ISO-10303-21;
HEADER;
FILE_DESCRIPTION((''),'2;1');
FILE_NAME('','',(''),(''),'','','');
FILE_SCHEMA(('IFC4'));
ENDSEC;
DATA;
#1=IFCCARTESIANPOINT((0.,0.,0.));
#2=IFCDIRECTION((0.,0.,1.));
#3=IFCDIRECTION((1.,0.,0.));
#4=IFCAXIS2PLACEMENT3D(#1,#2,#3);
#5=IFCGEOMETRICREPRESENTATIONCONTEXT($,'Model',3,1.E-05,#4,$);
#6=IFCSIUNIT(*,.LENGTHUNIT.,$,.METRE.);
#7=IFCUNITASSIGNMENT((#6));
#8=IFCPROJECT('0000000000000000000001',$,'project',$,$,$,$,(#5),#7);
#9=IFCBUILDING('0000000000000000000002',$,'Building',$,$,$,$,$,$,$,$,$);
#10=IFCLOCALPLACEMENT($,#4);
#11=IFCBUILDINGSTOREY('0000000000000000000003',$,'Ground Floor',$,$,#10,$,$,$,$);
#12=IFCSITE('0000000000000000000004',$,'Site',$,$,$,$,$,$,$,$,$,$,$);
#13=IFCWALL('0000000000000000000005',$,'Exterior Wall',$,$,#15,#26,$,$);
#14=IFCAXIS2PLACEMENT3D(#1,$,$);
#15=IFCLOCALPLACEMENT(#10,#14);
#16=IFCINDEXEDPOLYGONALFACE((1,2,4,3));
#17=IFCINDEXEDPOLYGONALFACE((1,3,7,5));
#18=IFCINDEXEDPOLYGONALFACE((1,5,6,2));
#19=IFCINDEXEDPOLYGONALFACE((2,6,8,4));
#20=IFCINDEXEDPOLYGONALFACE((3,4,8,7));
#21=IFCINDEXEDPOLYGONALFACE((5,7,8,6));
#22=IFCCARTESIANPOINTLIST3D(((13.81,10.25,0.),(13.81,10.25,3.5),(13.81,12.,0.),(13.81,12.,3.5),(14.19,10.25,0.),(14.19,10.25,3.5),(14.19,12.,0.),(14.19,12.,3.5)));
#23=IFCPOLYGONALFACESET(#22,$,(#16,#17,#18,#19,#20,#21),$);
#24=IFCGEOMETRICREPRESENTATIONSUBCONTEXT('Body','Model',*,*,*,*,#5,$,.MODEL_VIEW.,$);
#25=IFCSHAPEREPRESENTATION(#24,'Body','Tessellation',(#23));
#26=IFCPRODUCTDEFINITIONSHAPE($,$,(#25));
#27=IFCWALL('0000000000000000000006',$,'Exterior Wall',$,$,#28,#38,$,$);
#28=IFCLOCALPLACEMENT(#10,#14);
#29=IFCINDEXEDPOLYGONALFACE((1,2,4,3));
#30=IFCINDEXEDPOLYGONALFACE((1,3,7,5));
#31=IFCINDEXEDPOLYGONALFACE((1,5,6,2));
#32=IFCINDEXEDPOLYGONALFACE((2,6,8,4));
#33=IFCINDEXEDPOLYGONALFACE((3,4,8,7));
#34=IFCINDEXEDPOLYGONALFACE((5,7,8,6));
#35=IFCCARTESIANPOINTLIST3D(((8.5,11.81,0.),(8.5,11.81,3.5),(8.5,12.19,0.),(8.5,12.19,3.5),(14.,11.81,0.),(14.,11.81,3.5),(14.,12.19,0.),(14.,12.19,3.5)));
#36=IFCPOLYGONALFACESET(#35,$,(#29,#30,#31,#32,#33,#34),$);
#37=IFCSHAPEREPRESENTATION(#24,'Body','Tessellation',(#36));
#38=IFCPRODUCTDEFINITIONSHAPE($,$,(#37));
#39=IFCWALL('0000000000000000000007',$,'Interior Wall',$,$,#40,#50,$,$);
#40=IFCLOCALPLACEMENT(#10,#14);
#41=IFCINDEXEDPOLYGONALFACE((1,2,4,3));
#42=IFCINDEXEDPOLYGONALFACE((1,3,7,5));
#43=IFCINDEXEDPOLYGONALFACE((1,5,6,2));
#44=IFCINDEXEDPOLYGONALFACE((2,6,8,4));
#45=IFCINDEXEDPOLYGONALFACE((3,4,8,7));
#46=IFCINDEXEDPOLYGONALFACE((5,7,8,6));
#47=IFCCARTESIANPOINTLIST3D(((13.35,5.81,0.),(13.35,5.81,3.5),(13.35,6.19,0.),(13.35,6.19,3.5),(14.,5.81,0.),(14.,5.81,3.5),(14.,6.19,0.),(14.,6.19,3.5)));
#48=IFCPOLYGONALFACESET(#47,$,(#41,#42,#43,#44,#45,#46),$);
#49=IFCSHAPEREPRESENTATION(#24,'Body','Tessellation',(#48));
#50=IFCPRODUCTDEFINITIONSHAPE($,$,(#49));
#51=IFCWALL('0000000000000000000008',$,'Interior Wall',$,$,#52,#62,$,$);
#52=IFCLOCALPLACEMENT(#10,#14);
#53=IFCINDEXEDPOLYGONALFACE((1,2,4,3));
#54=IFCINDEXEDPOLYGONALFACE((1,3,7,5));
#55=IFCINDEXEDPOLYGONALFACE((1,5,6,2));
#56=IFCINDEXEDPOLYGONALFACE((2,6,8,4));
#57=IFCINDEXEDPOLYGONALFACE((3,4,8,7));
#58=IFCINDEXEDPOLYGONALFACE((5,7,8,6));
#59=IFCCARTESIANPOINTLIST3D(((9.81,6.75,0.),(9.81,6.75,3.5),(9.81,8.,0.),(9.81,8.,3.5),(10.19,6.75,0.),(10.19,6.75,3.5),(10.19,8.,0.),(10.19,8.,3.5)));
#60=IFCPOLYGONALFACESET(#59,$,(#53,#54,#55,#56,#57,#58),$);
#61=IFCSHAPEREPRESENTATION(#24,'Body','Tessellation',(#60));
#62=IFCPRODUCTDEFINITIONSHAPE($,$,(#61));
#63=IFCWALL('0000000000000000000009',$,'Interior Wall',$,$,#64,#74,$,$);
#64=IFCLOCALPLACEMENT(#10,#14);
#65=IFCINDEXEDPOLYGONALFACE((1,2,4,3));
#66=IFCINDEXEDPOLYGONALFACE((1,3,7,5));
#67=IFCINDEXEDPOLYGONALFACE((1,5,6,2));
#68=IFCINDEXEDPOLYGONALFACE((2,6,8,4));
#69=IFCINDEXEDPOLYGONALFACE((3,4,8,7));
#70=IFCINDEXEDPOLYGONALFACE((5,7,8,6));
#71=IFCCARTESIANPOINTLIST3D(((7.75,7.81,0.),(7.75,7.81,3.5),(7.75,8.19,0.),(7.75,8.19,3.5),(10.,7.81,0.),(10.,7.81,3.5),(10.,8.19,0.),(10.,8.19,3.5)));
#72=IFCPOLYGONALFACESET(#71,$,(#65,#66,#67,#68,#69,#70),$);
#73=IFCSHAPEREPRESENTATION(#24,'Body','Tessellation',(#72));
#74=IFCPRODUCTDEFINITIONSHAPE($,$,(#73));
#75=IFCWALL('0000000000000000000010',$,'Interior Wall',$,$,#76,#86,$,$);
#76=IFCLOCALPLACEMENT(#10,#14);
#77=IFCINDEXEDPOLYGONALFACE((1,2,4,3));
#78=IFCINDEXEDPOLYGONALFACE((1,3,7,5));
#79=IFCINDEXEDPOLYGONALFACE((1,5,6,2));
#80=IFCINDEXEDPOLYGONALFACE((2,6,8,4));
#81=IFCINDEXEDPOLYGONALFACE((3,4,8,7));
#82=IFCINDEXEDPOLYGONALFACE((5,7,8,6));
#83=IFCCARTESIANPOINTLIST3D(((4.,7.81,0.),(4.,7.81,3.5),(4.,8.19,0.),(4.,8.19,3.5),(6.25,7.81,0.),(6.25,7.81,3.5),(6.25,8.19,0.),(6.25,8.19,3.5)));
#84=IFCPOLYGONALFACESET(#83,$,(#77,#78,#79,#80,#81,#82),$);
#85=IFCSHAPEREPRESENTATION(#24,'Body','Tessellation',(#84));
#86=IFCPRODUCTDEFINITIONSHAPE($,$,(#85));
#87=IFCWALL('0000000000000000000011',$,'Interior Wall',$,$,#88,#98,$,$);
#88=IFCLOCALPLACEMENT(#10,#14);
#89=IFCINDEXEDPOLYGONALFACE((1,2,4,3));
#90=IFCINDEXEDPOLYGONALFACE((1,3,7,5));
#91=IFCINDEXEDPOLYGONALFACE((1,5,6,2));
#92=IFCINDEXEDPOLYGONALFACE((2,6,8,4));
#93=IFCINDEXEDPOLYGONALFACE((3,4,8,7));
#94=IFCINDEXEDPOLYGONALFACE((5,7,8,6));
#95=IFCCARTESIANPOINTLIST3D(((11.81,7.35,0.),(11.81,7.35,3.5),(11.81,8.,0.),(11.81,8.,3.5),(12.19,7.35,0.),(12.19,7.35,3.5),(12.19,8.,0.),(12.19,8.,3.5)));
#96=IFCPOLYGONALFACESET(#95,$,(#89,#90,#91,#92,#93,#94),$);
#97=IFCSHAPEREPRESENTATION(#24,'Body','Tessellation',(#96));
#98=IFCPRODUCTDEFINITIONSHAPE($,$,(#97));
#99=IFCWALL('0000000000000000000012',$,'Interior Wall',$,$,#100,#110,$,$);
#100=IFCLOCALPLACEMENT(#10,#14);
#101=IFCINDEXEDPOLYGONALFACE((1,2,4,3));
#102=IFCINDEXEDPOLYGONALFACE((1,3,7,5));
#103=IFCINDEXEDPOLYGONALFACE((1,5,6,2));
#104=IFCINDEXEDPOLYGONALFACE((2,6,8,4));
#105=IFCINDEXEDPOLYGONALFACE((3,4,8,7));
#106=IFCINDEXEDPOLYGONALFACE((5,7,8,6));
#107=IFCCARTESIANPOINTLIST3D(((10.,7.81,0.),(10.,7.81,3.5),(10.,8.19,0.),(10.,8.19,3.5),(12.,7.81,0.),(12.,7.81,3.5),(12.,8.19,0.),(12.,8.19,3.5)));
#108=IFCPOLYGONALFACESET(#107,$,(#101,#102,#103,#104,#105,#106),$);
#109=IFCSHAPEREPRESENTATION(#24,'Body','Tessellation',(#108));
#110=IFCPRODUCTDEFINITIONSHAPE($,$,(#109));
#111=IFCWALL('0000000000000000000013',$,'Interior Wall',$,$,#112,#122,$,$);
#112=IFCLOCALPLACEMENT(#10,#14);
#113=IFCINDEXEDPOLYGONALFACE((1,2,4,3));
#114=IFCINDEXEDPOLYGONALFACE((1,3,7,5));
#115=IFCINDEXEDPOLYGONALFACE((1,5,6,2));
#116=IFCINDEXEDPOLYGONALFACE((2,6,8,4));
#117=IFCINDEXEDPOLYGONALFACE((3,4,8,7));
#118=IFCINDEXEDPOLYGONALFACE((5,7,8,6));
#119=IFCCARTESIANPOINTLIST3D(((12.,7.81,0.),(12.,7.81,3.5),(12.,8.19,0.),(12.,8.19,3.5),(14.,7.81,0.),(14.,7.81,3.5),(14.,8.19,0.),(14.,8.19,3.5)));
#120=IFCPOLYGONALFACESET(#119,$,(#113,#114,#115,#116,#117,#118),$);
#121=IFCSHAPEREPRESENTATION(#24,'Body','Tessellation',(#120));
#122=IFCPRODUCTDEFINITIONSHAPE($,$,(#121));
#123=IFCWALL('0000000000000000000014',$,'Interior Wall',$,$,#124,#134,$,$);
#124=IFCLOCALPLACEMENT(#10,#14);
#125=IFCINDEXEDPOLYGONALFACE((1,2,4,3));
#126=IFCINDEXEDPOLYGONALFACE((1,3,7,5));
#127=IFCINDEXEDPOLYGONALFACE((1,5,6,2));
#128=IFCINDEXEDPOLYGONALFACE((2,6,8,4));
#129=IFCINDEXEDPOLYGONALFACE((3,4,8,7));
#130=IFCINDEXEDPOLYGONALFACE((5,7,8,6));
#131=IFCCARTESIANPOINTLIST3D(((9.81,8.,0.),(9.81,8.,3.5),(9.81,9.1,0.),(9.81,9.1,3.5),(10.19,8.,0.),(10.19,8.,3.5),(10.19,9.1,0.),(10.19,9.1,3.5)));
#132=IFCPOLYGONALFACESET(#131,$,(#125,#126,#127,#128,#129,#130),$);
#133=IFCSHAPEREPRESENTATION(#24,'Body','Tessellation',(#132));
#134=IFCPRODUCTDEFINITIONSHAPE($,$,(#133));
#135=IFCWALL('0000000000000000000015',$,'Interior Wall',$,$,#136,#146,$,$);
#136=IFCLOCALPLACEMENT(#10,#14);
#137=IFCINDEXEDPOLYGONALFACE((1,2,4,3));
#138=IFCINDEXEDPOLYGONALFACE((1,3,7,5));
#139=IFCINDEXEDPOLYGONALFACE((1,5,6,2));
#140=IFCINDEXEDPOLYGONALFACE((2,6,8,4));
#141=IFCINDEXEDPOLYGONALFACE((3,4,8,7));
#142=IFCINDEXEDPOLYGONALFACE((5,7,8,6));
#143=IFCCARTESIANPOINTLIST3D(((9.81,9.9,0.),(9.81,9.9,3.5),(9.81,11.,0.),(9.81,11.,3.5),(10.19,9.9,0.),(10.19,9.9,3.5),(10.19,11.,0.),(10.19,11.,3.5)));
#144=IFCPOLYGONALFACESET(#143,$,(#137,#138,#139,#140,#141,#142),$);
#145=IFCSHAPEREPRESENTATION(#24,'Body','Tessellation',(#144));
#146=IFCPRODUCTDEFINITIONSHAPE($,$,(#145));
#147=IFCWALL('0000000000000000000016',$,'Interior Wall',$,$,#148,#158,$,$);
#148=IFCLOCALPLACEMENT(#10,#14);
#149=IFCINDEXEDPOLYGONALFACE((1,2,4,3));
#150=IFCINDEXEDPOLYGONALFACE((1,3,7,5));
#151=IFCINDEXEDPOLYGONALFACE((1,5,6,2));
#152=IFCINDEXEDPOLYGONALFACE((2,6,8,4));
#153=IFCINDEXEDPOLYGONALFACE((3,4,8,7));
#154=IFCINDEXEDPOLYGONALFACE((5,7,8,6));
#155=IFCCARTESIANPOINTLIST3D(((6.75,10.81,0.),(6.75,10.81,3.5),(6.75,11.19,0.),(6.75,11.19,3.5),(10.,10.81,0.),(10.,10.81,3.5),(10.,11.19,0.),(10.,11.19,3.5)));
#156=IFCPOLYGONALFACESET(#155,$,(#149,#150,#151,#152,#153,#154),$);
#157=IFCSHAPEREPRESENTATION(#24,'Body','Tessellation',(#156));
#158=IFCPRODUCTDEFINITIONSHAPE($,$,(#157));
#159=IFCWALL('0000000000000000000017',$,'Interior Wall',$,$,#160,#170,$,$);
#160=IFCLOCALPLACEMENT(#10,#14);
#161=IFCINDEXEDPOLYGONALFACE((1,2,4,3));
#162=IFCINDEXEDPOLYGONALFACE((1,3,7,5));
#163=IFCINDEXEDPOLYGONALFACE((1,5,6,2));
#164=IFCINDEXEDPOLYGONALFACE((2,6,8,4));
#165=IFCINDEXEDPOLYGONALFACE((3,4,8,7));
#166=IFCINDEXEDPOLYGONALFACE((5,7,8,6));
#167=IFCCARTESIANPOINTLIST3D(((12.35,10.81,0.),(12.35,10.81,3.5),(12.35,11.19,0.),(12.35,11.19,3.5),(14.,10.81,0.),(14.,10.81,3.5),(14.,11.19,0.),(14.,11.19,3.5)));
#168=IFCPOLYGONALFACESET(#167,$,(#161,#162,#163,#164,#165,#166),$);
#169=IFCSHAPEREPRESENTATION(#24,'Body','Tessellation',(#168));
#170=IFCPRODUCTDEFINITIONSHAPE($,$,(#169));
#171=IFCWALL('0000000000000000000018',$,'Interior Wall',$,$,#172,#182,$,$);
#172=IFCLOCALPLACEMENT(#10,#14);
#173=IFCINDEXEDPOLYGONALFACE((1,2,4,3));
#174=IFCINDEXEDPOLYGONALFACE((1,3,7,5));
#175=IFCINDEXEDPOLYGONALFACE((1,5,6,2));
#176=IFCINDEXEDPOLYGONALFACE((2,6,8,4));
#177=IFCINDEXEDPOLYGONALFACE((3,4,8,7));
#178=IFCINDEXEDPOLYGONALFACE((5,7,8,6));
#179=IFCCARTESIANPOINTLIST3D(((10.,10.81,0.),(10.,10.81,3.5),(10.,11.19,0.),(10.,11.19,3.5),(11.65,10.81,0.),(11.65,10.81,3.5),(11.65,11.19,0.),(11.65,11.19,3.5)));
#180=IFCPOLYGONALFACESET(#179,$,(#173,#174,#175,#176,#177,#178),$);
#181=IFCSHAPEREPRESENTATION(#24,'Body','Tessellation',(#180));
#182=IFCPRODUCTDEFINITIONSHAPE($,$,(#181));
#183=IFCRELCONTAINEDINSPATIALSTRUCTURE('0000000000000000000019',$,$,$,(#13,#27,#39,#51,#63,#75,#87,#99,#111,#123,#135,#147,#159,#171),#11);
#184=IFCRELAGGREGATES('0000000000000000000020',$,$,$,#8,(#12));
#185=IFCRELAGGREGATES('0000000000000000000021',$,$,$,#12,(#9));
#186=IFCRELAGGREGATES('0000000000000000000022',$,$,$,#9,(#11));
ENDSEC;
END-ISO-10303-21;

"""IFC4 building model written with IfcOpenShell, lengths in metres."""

from ifc_helpers import new_model, si_unit, frame, origin_with_axes, place, context, subcontext, project, spatial, indexed_curve, outline, extrude, element, save


model = new_model("IFC4")

# Units and contexts
model_context = context("Model", 3, precision=1e-05, world=origin_with_axes())
body_context = subcontext(model_context, "Body", "Model", "MODEL_VIEW")
ifc_project = project(units=[si_unit("LENGTHUNIT", "METRE")], contexts=[model_context])

# Site, building, storey
site = spatial("IfcSite", under=ifc_project, Name="Site")
building = spatial("IfcBuilding", under=site, Name="Building")
storey_placement = place(None, origin_with_axes())
storey = spatial("IfcBuildingStorey", under=building, at=storey_placement, Name="Ground Floor")

# Walls
wall_1_placement = place(storey_placement, frame((14.0, 10.25, 0.0), z_axis=(0.0, 0.0, 1.0), x_axis=(0.0, 1.0, 0.0)))
element("IfcWall", 1, at=wall_1_placement, inside=storey, Name="Exterior Wall", context=body_context, shape_type="SweptSolid", body=[
    extrude(outline(indexed_curve([(0.0, 0.0), (0.0, 0.38), (1.75, 0.38), (1.75, 0.0), (0.0, 0.0)], self_intersect=False)), frame((0.0, -0.19, 0.0), z_axis=(0.0, 0.0, 1.0), x_axis=(1.0, 0.0, 0.0)), (0.0, 0.0, 1.0), 3.5),
])
wall_2_placement = place(storey_placement, frame((14.0, 12.0, 0.0), z_axis=(0.0, 0.0, 1.0), x_axis=(-1.0, 0.0, 0.0)))
element("IfcWall", 2, at=wall_2_placement, inside=storey, Name="Exterior Wall", context=body_context, shape_type="SweptSolid", body=[
    extrude(outline(indexed_curve([(0.0, 0.0), (0.0, 0.38), (5.5, 0.38), (5.5, 0.0), (0.0, 0.0)], self_intersect=False)), frame((0.0, -0.19, 0.0), z_axis=(0.0, 0.0, 1.0), x_axis=(1.0, 0.0, 0.0)), (0.0, 0.0, 1.0), 3.5),
])
wall_3_placement = place(storey_placement, frame((14.0, 6.0, 0.0), z_axis=(0.0, 0.0, 1.0), x_axis=(-1.0, 0.0, 0.0)))
element("IfcWall", 3, at=wall_3_placement, inside=storey, Name="Interior Wall", context=body_context, shape_type="SweptSolid", body=[
    extrude(outline(indexed_curve([(0.0, 0.0), (0.0, 0.38), (0.65, 0.38), (0.65, 0.0), (0.0, 0.0)], self_intersect=False)), frame((0.0, -0.19, 0.0), z_axis=(0.0, 0.0, 1.0), x_axis=(1.0, 0.0, 0.0)), (0.0, 0.0, 1.0), 3.5),
])
wall_4_placement = place(storey_placement, frame((10.0, 6.75, 0.0), z_axis=(0.0, 0.0, 1.0), x_axis=(0.0, 1.0, 0.0)))
element("IfcWall", 4, at=wall_4_placement, inside=storey, Name="Interior Wall", context=body_context, shape_type="SweptSolid", body=[
    extrude(outline(indexed_curve([(0.0, 0.0), (0.0, 0.38), (1.25, 0.38), (1.25, 0.0), (0.0, 0.0)], self_intersect=False)), frame((0.0, -0.19, 0.0), z_axis=(0.0, 0.0, 1.0), x_axis=(1.0, 0.0, 0.0)), (0.0, 0.0, 1.0), 3.5),
])
for number, where, z_axis, x_axis, name in (
    (5, (10.0, 8.0, 0.0), (0.0, 0.0, 1.0), (-1.0, 0.0, 0.0), "Interior Wall"),
    (6, (6.25, 8.0, 0.0), (0.0, 0.0, 1.0), (-1.0, 0.0, 0.0), "Interior Wall"),
):
    element("IfcWall", number, at=place(storey_placement, frame(where, z_axis=z_axis, x_axis=x_axis)), inside=storey, Name=name, context=body_context, shape_type="SweptSolid", body=[
        extrude(outline(indexed_curve([(0.0, 0.0), (0.0, 0.38), (2.25, 0.38), (2.25, 0.0), (0.0, 0.0)], self_intersect=False)), frame((0.0, -0.19, 0.0), z_axis=(0.0, 0.0, 1.0), x_axis=(1.0, 0.0, 0.0)), (0.0, 0.0, 1.0), 3.5),
    ])
wall_5_placement = place(storey_placement, frame((12.0, 7.35, 0.0), z_axis=(0.0, 0.0, 1.0), x_axis=(0.0, 1.0, 0.0)))
element("IfcWall", 7, at=wall_5_placement, inside=storey, Name="Interior Wall", context=body_context, shape_type="SweptSolid", body=[
    extrude(outline(indexed_curve([(0.0, 0.0), (0.0, 0.38), (0.65, 0.38), (0.65, 0.0), (0.0, 0.0)], self_intersect=False)), frame((0.0, -0.19, 0.0), z_axis=(0.0, 0.0, 1.0), x_axis=(1.0, 0.0, 0.0)), (0.0, 0.0, 1.0), 3.5),
])
for number, where, z_axis, x_axis, name in (
    (8, (12.0, 8.0, 0.0), (0.0, 0.0, 1.0), (-1.0, 0.0, 0.0), "Interior Wall"),
    (9, (14.0, 8.0, 0.0), (0.0, 0.0, 1.0), (-1.0, 0.0, 0.0), "Interior Wall"),
):
    element("IfcWall", number, at=place(storey_placement, frame(where, z_axis=z_axis, x_axis=x_axis)), inside=storey, Name=name, context=body_context, shape_type="SweptSolid", body=[
        extrude(outline(indexed_curve([(0.0, 0.0), (0.0, 0.38), (2.0, 0.38), (2.0, 0.0), (0.0, 0.0)], self_intersect=False)), frame((0.0, -0.19, 0.0), z_axis=(0.0, 0.0, 1.0), x_axis=(1.0, 0.0, 0.0)), (0.0, 0.0, 1.0), 3.5),
    ])
for number, where, z_axis, x_axis, name in (
    (10, (10.0, 8.0, 0.0), (0.0, 0.0, 1.0), (0.0, 1.0, 0.0), "Interior Wall"),
    (11, (10.0, 9.9, 0.0), (0.0, 0.0, 1.0), (0.0, 1.0, 0.0), "Interior Wall"),
):
    element("IfcWall", number, at=place(storey_placement, frame(where, z_axis=z_axis, x_axis=x_axis)), inside=storey, Name=name, context=body_context, shape_type="SweptSolid", body=[
        extrude(outline(indexed_curve([(0.0, 0.0), (0.0, 0.38), (1.1, 0.38), (1.1, 0.0), (0.0, 0.0)], self_intersect=False)), frame((0.0, -0.19, 0.0), z_axis=(0.0, 0.0, 1.0), x_axis=(1.0, 0.0, 0.0)), (0.0, 0.0, 1.0), 3.5),
    ])
wall_6_placement = place(storey_placement, frame((10.0, 11.0, 0.0), z_axis=(0.0, 0.0, 1.0), x_axis=(-1.0, 0.0, 0.0)))
element("IfcWall", 12, at=wall_6_placement, inside=storey, Name="Interior Wall", context=body_context, shape_type="SweptSolid", body=[
    extrude(outline(indexed_curve([(0.0, 0.0), (0.0, 0.38), (3.25, 0.38), (3.25, 0.0), (0.0, 0.0)], self_intersect=False)), frame((0.0, -0.19, 0.0), z_axis=(0.0, 0.0, 1.0), x_axis=(1.0, 0.0, 0.0)), (0.0, 0.0, 1.0), 3.5),
])
for number, where, z_axis, x_axis, name in (
    (13, (14.0, 11.0, 0.0), (0.0, 0.0, 1.0), (-1.0, 0.0, 0.0), "Interior Wall"),
    (14, (11.65, 11.0, 0.0), (0.0, 0.0, 1.0), (-1.0, 0.0, 0.0), "Interior Wall"),
):
    element("IfcWall", number, at=place(storey_placement, frame(where, z_axis=z_axis, x_axis=x_axis)), inside=storey, Name=name, context=body_context, shape_type="SweptSolid", body=[
        extrude(outline(indexed_curve([(0.0, 0.0), (0.0, 0.38), (1.65, 0.38), (1.65, 0.0), (0.0, 0.0)], self_intersect=False)), frame((0.0, -0.19, 0.0), z_axis=(0.0, 0.0, 1.0), x_axis=(1.0, 0.0, 0.0)), (0.0, 0.0, 1.0), 3.5),
    ])

save(model, "model.ifc")
